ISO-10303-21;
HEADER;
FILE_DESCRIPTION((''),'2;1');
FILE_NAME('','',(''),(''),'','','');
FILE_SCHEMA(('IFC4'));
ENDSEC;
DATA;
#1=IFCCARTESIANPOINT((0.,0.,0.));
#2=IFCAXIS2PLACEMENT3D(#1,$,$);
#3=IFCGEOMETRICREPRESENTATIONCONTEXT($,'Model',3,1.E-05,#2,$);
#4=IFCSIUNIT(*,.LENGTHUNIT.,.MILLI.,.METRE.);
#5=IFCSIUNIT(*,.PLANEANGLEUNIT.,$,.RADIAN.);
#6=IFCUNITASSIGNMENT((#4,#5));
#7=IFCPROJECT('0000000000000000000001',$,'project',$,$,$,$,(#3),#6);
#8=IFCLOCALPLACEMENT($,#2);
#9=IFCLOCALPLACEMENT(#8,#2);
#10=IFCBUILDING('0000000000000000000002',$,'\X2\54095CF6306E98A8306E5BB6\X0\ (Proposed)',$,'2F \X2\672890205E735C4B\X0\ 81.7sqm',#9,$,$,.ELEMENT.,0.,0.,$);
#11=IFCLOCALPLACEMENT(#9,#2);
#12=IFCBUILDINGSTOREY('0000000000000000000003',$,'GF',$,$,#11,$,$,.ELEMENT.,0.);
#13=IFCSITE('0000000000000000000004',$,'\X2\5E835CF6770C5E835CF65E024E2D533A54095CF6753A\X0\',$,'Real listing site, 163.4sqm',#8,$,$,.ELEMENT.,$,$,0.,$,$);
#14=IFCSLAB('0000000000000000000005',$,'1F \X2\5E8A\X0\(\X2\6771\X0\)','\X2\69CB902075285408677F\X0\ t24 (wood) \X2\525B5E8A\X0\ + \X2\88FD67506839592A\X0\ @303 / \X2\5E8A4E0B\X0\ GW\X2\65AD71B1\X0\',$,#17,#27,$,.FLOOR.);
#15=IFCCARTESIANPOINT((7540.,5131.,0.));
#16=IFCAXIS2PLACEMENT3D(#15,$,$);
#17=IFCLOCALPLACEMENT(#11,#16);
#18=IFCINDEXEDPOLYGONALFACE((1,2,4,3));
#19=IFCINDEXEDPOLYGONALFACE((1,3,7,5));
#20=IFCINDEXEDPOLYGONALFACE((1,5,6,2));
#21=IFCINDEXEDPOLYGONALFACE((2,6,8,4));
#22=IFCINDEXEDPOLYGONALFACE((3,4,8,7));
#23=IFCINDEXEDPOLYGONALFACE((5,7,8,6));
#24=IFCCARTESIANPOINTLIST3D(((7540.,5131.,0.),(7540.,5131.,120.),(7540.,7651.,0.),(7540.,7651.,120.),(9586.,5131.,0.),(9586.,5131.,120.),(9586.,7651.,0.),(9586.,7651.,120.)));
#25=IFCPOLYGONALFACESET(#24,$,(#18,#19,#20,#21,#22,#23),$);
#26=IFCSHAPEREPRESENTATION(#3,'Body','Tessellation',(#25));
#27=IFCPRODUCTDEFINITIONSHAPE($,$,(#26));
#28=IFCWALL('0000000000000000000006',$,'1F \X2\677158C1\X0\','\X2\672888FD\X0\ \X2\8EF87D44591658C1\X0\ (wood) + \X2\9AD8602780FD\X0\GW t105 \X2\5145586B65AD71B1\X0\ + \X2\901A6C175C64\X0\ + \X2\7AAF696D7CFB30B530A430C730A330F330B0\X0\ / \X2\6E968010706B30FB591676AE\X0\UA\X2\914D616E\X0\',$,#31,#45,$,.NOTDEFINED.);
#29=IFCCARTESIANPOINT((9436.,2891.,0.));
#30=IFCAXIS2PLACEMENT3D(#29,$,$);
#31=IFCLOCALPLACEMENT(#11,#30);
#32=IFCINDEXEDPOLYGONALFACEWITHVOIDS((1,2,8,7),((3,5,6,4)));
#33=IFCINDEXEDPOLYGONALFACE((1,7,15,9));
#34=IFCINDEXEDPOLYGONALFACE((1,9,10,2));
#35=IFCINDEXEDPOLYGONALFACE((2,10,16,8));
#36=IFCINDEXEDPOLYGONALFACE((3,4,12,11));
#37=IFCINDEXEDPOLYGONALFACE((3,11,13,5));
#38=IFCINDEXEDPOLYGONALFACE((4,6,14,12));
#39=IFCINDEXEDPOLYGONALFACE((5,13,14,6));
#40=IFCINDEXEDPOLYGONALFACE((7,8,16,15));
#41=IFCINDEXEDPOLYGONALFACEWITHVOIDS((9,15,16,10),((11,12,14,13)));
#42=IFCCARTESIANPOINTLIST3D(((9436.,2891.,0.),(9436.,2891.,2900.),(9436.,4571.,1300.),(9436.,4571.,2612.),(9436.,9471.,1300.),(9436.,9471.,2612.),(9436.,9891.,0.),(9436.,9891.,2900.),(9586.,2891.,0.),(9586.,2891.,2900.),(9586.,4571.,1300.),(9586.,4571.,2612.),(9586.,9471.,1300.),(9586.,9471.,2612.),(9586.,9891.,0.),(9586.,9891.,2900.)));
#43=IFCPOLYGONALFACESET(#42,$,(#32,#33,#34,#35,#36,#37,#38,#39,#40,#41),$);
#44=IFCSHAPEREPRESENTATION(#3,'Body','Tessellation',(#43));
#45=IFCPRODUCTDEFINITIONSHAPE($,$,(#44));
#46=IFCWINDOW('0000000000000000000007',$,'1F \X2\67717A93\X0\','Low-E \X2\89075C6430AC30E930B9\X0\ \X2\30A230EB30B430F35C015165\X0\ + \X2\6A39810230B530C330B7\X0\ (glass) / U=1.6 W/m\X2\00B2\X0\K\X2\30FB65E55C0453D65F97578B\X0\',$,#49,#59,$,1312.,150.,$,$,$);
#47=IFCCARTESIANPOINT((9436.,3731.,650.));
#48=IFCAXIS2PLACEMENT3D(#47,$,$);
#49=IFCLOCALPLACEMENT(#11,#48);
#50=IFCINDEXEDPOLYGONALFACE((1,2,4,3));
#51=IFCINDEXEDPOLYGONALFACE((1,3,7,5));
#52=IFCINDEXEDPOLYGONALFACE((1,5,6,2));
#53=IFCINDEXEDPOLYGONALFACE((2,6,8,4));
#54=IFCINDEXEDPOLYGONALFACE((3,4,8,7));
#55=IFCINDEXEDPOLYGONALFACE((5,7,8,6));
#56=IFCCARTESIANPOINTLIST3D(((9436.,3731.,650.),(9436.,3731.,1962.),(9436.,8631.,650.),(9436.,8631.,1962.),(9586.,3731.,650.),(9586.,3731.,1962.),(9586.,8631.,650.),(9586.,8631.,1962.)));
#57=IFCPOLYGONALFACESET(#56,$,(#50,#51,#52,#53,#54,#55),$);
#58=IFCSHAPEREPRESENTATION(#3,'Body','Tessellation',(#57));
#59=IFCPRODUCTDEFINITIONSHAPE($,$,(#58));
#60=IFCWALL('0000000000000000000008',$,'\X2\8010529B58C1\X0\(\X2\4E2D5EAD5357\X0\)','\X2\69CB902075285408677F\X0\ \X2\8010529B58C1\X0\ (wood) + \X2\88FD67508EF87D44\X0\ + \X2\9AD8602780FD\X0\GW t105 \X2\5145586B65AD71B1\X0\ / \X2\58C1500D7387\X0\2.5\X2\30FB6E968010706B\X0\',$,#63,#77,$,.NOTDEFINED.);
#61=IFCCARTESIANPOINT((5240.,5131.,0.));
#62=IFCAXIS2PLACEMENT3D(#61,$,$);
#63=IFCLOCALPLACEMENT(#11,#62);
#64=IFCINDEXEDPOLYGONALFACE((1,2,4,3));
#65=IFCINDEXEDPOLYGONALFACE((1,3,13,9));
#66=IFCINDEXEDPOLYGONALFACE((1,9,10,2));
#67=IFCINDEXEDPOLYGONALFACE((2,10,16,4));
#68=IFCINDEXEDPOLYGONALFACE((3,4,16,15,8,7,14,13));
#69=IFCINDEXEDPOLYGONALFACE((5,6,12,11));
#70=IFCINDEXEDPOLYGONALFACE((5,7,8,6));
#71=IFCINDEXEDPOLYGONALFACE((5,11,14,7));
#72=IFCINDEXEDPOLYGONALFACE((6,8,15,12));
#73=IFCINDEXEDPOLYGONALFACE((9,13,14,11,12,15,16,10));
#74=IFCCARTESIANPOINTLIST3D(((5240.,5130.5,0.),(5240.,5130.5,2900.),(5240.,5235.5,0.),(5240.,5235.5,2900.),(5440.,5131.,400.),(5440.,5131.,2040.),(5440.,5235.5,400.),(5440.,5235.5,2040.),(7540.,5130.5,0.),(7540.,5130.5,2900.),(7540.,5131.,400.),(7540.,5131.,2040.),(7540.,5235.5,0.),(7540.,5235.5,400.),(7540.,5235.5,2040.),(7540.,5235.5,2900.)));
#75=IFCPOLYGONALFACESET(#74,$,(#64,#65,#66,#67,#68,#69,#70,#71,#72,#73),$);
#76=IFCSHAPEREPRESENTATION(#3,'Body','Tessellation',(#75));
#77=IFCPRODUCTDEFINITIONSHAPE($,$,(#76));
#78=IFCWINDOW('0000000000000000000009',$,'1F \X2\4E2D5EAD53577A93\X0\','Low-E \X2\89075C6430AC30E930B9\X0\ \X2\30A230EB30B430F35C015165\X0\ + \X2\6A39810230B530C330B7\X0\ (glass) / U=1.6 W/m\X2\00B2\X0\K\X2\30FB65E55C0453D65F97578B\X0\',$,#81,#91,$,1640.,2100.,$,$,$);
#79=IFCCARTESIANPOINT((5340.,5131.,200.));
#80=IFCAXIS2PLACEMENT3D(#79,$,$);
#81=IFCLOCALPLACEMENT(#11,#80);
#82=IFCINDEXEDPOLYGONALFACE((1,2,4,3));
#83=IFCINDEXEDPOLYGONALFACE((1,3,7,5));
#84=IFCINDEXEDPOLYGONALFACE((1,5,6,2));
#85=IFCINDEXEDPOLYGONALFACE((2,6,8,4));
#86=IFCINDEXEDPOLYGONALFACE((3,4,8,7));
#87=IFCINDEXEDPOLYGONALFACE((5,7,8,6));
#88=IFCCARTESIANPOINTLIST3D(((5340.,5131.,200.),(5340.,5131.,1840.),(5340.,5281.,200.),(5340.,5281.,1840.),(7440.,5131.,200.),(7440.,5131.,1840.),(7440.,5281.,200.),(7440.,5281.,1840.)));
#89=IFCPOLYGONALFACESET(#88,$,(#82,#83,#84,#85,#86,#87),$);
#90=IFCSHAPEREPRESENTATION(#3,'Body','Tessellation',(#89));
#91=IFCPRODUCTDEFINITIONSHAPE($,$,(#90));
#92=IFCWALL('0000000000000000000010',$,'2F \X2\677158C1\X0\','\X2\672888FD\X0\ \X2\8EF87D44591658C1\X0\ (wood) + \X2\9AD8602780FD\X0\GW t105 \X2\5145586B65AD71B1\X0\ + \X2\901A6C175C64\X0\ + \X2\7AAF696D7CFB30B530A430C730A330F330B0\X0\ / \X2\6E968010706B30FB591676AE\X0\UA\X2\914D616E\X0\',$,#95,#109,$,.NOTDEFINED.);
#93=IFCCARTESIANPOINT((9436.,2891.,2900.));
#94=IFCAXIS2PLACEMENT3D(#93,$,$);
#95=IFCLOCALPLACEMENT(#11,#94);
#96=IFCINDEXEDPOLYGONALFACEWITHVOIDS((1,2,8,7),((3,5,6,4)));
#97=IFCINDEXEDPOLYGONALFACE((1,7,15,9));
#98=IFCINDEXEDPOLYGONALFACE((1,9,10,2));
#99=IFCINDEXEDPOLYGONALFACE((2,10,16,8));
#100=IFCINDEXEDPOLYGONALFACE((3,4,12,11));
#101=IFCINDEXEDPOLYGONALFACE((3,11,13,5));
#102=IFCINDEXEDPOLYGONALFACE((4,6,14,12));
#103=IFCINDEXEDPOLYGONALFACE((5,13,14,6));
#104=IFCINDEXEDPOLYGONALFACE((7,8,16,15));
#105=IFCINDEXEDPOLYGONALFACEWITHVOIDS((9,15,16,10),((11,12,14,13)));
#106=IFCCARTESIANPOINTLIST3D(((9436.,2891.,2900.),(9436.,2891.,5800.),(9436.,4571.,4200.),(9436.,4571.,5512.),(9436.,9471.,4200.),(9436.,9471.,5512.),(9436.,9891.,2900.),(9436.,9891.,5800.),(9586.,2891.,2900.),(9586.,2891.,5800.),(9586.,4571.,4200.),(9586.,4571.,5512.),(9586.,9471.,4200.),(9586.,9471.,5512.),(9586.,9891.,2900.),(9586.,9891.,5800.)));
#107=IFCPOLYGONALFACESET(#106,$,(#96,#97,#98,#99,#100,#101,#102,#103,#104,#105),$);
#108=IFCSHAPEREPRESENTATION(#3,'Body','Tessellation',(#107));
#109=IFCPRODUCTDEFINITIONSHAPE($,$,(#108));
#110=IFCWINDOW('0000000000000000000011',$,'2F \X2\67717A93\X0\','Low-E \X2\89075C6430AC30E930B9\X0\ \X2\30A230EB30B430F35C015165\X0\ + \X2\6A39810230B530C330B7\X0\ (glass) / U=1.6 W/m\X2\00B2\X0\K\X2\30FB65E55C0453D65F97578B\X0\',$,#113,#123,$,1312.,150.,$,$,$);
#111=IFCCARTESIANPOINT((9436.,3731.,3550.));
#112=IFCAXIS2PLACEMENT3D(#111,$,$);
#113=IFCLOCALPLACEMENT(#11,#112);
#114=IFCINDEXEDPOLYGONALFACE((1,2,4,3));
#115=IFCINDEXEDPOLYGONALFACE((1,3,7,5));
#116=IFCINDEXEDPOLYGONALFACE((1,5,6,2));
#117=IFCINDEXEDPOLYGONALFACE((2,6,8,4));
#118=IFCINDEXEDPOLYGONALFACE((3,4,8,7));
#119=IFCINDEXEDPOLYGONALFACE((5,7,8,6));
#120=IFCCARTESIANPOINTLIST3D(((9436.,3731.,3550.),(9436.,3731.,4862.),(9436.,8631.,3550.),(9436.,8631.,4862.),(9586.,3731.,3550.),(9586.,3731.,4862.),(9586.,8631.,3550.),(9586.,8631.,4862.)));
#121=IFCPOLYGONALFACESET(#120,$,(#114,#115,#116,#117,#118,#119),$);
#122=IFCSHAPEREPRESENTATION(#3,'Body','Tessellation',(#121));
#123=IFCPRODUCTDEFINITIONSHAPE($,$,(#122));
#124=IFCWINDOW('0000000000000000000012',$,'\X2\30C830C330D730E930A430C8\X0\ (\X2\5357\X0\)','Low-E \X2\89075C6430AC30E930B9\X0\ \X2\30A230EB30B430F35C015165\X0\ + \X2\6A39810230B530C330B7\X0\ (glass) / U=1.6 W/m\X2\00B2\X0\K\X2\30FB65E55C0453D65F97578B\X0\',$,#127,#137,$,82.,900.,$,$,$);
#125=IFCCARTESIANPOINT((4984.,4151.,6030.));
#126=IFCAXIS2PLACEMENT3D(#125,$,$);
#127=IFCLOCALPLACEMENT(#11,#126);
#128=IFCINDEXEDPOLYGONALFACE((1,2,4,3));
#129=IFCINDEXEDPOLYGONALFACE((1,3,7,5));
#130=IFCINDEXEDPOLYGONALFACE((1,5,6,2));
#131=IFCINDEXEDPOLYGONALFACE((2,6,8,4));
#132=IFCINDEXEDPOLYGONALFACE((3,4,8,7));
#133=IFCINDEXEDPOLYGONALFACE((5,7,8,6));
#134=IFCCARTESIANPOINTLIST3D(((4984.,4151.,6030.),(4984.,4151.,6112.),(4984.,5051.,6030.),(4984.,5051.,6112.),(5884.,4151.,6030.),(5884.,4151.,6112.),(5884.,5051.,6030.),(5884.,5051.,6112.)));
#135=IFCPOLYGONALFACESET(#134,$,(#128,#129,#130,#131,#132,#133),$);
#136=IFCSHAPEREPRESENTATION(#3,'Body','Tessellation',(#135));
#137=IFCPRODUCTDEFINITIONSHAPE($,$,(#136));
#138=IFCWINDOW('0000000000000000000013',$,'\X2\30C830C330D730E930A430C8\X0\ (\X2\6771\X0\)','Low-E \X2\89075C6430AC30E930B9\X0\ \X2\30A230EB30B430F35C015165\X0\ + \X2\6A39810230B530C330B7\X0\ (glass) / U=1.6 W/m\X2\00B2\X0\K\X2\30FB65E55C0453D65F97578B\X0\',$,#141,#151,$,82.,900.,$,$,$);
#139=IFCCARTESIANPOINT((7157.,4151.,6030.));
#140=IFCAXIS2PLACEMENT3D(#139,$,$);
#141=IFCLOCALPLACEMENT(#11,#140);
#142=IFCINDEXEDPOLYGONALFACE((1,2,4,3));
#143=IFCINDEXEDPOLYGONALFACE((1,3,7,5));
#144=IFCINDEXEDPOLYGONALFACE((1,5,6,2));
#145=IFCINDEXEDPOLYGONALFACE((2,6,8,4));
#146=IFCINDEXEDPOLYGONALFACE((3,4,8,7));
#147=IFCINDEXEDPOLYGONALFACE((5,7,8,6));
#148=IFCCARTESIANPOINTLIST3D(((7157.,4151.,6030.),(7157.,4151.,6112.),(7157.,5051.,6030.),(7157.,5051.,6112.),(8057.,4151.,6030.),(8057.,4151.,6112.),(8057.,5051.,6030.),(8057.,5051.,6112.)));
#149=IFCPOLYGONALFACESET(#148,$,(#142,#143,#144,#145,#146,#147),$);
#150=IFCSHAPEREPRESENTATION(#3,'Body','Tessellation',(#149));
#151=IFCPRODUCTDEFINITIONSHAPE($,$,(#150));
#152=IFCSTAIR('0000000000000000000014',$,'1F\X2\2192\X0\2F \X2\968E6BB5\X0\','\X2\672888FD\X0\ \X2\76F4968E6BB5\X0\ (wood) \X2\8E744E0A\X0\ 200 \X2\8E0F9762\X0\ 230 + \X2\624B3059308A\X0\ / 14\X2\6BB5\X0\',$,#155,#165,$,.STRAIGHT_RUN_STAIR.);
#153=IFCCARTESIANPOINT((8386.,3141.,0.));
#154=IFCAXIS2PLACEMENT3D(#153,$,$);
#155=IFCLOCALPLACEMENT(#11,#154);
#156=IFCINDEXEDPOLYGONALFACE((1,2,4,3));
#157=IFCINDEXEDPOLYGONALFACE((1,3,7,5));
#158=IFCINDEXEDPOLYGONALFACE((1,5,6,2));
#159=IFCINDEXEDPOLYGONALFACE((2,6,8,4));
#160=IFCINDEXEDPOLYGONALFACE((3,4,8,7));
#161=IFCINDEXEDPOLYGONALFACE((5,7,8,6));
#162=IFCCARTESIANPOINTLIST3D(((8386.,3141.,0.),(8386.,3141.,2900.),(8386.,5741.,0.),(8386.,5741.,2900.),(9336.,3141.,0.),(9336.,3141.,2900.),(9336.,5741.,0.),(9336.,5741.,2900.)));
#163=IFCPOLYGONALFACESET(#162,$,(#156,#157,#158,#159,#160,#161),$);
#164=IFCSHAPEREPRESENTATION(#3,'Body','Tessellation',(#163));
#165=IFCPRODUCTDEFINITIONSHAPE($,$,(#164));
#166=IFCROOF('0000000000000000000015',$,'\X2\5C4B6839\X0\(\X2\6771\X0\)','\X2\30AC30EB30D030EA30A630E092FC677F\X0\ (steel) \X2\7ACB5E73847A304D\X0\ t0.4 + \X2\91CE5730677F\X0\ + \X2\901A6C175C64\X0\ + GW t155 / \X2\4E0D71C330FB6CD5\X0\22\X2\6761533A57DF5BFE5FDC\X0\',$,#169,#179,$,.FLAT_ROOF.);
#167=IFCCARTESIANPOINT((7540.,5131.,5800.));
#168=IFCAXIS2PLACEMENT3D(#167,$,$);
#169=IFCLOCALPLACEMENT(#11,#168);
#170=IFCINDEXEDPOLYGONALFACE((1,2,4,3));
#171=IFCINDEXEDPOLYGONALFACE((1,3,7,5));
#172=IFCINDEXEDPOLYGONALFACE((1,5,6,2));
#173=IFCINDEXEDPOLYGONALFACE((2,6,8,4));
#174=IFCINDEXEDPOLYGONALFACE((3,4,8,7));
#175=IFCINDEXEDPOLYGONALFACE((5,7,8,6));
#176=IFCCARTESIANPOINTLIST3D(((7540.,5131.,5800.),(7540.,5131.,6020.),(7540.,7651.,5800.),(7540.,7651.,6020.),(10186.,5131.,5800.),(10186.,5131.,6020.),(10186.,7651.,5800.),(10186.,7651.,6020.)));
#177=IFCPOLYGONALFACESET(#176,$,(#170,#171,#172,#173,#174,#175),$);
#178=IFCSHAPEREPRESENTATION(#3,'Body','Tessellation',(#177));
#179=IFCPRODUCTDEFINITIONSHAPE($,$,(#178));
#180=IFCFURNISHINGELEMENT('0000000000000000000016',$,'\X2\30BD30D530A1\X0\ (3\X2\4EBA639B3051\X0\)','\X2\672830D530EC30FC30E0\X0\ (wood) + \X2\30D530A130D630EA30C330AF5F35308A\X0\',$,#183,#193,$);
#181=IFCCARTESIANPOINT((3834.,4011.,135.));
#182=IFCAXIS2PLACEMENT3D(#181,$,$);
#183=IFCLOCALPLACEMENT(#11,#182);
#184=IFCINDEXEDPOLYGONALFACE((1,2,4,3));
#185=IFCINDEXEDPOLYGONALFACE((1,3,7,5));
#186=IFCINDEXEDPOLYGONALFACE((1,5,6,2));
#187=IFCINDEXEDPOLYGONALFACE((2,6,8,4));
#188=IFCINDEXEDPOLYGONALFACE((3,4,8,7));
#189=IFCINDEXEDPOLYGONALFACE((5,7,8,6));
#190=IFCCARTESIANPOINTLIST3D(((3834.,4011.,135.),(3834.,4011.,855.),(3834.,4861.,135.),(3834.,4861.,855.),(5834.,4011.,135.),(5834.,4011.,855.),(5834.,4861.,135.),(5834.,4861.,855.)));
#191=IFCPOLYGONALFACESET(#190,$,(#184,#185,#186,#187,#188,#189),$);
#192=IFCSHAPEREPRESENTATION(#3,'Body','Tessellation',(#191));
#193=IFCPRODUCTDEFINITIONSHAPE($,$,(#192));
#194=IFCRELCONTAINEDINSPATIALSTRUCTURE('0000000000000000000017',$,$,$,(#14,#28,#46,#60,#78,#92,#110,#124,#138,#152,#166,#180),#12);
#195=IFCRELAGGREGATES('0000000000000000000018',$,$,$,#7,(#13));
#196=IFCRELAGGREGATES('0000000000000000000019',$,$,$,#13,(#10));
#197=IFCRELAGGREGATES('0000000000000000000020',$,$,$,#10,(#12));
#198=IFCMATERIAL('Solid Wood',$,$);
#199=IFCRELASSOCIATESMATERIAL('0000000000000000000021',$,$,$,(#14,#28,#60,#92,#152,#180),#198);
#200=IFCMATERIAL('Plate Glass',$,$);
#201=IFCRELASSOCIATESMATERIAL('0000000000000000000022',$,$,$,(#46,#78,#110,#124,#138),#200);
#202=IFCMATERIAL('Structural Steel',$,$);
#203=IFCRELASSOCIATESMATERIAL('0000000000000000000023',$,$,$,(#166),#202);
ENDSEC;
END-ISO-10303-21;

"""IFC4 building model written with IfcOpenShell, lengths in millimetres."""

from ifc_helpers import new_model, si_unit, frame, frame_2d, origin, place, context, project, spatial, rectangle, extrude, material, element, fill, save


model = new_model("IFC4")

# Units and contexts
model_context = context("Model", 3, precision=1e-05, world=origin())
ifc_project = project(units=[si_unit("LENGTHUNIT", "METRE", prefix="MILLI"), si_unit("PLANEANGLEUNIT", "RADIAN")], contexts=[model_context])

# Site, building, storey
site_placement = place(None, origin())
site = spatial("IfcSite", under=ifc_project, at=site_placement, Name="広島県広島市中区吉島町", ObjectType="Real listing site, 163.4sqm", CompositionType="ELEMENT", RefElevation=0.0)
building_placement = place(site_placement, origin())
building = spatial("IfcBuilding", under=site, at=building_placement, Name="吉島の風の家 (Proposed)", ObjectType="2F 木造平屋 81.7sqm", CompositionType="ELEMENT", ElevationOfRefHeight=0.0, ElevationOfTerrain=0.0)
storey_placement = place(building_placement, origin())
storey = spatial("IfcBuildingStorey", under=building, at=storey_placement, Name="GF", CompositionType="ELEMENT", Elevation=0.0)

# Slab
ifc_material_1 = material(Name="Solid Wood")
slab_placement = place(storey_placement, frame((7540.0, 5131.0, 0.0)))
element("IfcSlab", 1, at=slab_placement, inside=storey, material=ifc_material_1, Name="1F 床(東)", Description="構造用合板 t24 (wood) 剛床 + 製材根太 @303 / 床下 GW断熱", PredefinedType="FLOOR", context=model_context, shape_type="SweptSolid", body=[
    extrude(rectangle(XDim=2046.0, YDim=2520.0, at=frame_2d((1023.0, 1260.0))), frame((7540.0, 5131.0, 0.0)), (0.0, 0.0, 1.0), 120.0),
])

# Walls, openings, windows
wall_1_placement = place(storey_placement, frame((9436.0, 2891.0, 0.0)))
wall_1 = element("IfcWall", 2, at=wall_1_placement, inside=storey, material=ifc_material_1, Name="1F 東壁", Description="木製 軸組外壁 (wood) + 高性能GW t105 充填断熱 + 通気層 + 窯業系サイディング / 準耐火・外皮UA配慮", PredefinedType="NOTDEFINED", context=model_context, shape_type="SweptSolid", body=[
    extrude(rectangle(XDim=150.0, YDim=7000.0, at=frame_2d((75.0, 3500.0))), frame((9436.0, 2891.0, 0.0)), (0.0, 0.0, 1.0), 2900.0),
])
opening_1_placement = place(storey_placement, frame((9436.0, 3731.0, 650.0)))
opening_1 = element("IfcOpeningElement", 3, at=opening_1_placement, cuts=wall_1, PredefinedType="NOTDEFINED", context=model_context, shape_type="SweptSolid", body=[
    extrude(rectangle(XDim=150.0, YDim=4900.0, at=frame_2d((75.0, 2450.0))), frame((9436.0, 3731.0, 650.0)), (0.0, 0.0, 1.0), 1312.0),
])
ifc_material_2 = material(Name="Plate Glass")
window_1_placement = place(storey_placement, frame((9436.0, 3731.0, 650.0)))
window_1 = element("IfcWindow", 4, at=window_1_placement, inside=storey, material=ifc_material_2, Name="1F 東窓", Description="Low-E 複層ガラス アルゴン封入 + 樹脂サッシ (glass) / U=1.6 W/m²K・日射取得型", OverallHeight=1312.0, OverallWidth=150.0, context=model_context, shape_type="SweptSolid", body=[
    extrude(rectangle(XDim=150.0, YDim=4900.0, at=frame_2d((75.0, 2450.0))), frame((9436.0, 3731.0, 650.0)), (0.0, 0.0, 1.0), 1312.0),
])
fill(opening_1, window_1)
wall_2_placement = place(storey_placement, frame((5240.0, 5131.0, 0.0)))
wall_2 = element("IfcWall", 5, at=wall_2_placement, inside=storey, material=ifc_material_1, Name="耐力壁(中庭南)", Description="構造用合板 耐力壁 (wood) + 製材軸組 + 高性能GW t105 充填断熱 / 壁倍率2.5・準耐火", PredefinedType="NOTDEFINED", context=model_context, shape_type="SweptSolid", body=[
    extrude(rectangle(XDim=2300.0, YDim=105.0, at=frame_2d((1150.0, 52.0))), frame((5240.0, 5131.0, 0.0)), (0.0, 0.0, 1.0), 2900.0),
])
opening_2_placement = place(storey_placement, frame((5340.0, 5131.0, 200.0)))
opening_2 = element("IfcOpeningElement", 6, at=opening_2_placement, cuts=wall_2, PredefinedType="NOTDEFINED", context=model_context, shape_type="SweptSolid", body=[
    extrude(rectangle(XDim=2100.0, YDim=150.0, at=frame_2d((1050.0, 75.0))), frame((5340.0, 5131.0, 200.0)), (0.0, 0.0, 1.0), 1640.0),
])
window_2_placement = place(storey_placement, frame((5340.0, 5131.0, 200.0)))
window_2 = element("IfcWindow", 7, at=window_2_placement, inside=storey, material=ifc_material_2, Name="1F 中庭南窓", Description="Low-E 複層ガラス アルゴン封入 + 樹脂サッシ (glass) / U=1.6 W/m²K・日射取得型", OverallHeight=1640.0, OverallWidth=2100.0, context=model_context, shape_type="SweptSolid", body=[
    extrude(rectangle(XDim=2100.0, YDim=150.0, at=frame_2d((1050.0, 75.0))), frame((5340.0, 5131.0, 200.0)), (0.0, 0.0, 1.0), 1640.0),
])
fill(opening_2, window_2)

# Wall, opening, window
wall_3_placement = place(storey_placement, frame((9436.0, 2891.0, 2900.0)))
wall_3 = element("IfcWall", 8, at=wall_3_placement, inside=storey, material=ifc_material_1, Name="2F 東壁", Description="木製 軸組外壁 (wood) + 高性能GW t105 充填断熱 + 通気層 + 窯業系サイディング / 準耐火・外皮UA配慮", PredefinedType="NOTDEFINED", context=model_context, shape_type="SweptSolid", body=[
    extrude(rectangle(XDim=150.0, YDim=7000.0, at=frame_2d((75.0, 3500.0))), frame((9436.0, 2891.0, 2900.0)), (0.0, 0.0, 1.0), 2900.0),
])
opening_3_placement = place(storey_placement, frame((9436.0, 3731.0, 3550.0)))
opening_3 = element("IfcOpeningElement", 9, at=opening_3_placement, cuts=wall_3, PredefinedType="NOTDEFINED", context=model_context, shape_type="SweptSolid", body=[
    extrude(rectangle(XDim=150.0, YDim=4900.0, at=frame_2d((75.0, 2450.0))), frame((9436.0, 3731.0, 3550.0)), (0.0, 0.0, 1.0), 1312.0),
])
window_3_placement = place(storey_placement, frame((9436.0, 3731.0, 3550.0)))
window_3 = element("IfcWindow", 10, at=window_3_placement, inside=storey, material=ifc_material_2, Name="2F 東窓", Description="Low-E 複層ガラス アルゴン封入 + 樹脂サッシ (glass) / U=1.6 W/m²K・日射取得型", OverallHeight=1312.0, OverallWidth=150.0, context=model_context, shape_type="SweptSolid", body=[
    extrude(rectangle(XDim=150.0, YDim=4900.0, at=frame_2d((75.0, 2450.0))), frame((9436.0, 3731.0, 3550.0)), (0.0, 0.0, 1.0), 1312.0),
])
fill(opening_3, window_3)

# Windows
window_4_placement = place(storey_placement, frame((4984.0, 4151.0, 6030.0)))
element("IfcWindow", 11, at=window_4_placement, inside=storey, material=ifc_material_2, Name="トップライト (南)", Description="Low-E 複層ガラス アルゴン封入 + 樹脂サッシ (glass) / U=1.6 W/m²K・日射取得型", OverallHeight=82.0, OverallWidth=900.0, context=model_context, shape_type="SweptSolid", body=[
    extrude(rectangle(XDim=900.0, YDim=900.0, at=frame_2d((450.0, 450.0))), frame((4984.0, 4151.0, 6030.0)), (0.0, 0.0, 1.0), 82.0),
])
window_5_placement = place(storey_placement, frame((7157.0, 4151.0, 6030.0)))
element("IfcWindow", 12, at=window_5_placement, inside=storey, material=ifc_material_2, Name="トップライト (東)", Description="Low-E 複層ガラス アルゴン封入 + 樹脂サッシ (glass) / U=1.6 W/m²K・日射取得型", OverallHeight=82.0, OverallWidth=900.0, context=model_context, shape_type="SweptSolid", body=[
    extrude(rectangle(XDim=900.0, YDim=900.0, at=frame_2d((450.0, 450.0))), frame((7157.0, 4151.0, 6030.0)), (0.0, 0.0, 1.0), 82.0),
])

# Stair
stair_placement = place(storey_placement, frame((8386.0, 3141.0, 0.0)))
element("IfcStair", 13, at=stair_placement, inside=storey, material=ifc_material_1, Name="1F→2F 階段", Description="木製 直階段 (wood) 蹴上 200 踏面 230 + 手すり / 14段", PredefinedType="STRAIGHT_RUN_STAIR", context=model_context, shape_type="SweptSolid", body=[
    extrude(rectangle(XDim=950.0, YDim=2600.0, at=frame_2d((475.0, 1300.0))), frame((8386.0, 3141.0, 0.0)), (0.0, 0.0, 1.0), 2900.0),
])

# Roof
ifc_material_3 = material(Name="Structural Steel")
roof_placement = place(storey_placement, frame((7540.0, 5131.0, 5800.0)))
element("IfcRoof", 14, at=roof_placement, inside=storey, material=ifc_material_3, Name="屋根(東)", Description="ガルバリウム鋼板 (steel) 立平葺き t0.4 + 野地板 + 通気層 + GW t155 / 不燃・法22条区域対応", PredefinedType="FLAT_ROOF", context=model_context, shape_type="SweptSolid", body=[
    extrude(rectangle(XDim=2646.0, YDim=2520.0, at=frame_2d((1323.0, 1260.0))), frame((7540.0, 5131.0, 5800.0)), (0.0, 0.0, 1.0), 220.0),
])

# Furnishing element
furnishing_1_placement = place(storey_placement, frame((3834.0, 4011.0, 135.0)))
element("IfcFurnishingElement", 15, at=furnishing_1_placement, inside=storey, material=ifc_material_1, Name="ソファ (3人掛け)", Description="木フレーム (wood) + ファブリック張り", context=model_context, shape_type="SweptSolid", body=[
    extrude(rectangle(XDim=2000.0, YDim=850.0, at=frame_2d((1000.0, 425.0))), frame((3834.0, 4011.0, 135.0)), (0.0, 0.0, 1.0), 720.0),
])

save(model, "model.ifc")
